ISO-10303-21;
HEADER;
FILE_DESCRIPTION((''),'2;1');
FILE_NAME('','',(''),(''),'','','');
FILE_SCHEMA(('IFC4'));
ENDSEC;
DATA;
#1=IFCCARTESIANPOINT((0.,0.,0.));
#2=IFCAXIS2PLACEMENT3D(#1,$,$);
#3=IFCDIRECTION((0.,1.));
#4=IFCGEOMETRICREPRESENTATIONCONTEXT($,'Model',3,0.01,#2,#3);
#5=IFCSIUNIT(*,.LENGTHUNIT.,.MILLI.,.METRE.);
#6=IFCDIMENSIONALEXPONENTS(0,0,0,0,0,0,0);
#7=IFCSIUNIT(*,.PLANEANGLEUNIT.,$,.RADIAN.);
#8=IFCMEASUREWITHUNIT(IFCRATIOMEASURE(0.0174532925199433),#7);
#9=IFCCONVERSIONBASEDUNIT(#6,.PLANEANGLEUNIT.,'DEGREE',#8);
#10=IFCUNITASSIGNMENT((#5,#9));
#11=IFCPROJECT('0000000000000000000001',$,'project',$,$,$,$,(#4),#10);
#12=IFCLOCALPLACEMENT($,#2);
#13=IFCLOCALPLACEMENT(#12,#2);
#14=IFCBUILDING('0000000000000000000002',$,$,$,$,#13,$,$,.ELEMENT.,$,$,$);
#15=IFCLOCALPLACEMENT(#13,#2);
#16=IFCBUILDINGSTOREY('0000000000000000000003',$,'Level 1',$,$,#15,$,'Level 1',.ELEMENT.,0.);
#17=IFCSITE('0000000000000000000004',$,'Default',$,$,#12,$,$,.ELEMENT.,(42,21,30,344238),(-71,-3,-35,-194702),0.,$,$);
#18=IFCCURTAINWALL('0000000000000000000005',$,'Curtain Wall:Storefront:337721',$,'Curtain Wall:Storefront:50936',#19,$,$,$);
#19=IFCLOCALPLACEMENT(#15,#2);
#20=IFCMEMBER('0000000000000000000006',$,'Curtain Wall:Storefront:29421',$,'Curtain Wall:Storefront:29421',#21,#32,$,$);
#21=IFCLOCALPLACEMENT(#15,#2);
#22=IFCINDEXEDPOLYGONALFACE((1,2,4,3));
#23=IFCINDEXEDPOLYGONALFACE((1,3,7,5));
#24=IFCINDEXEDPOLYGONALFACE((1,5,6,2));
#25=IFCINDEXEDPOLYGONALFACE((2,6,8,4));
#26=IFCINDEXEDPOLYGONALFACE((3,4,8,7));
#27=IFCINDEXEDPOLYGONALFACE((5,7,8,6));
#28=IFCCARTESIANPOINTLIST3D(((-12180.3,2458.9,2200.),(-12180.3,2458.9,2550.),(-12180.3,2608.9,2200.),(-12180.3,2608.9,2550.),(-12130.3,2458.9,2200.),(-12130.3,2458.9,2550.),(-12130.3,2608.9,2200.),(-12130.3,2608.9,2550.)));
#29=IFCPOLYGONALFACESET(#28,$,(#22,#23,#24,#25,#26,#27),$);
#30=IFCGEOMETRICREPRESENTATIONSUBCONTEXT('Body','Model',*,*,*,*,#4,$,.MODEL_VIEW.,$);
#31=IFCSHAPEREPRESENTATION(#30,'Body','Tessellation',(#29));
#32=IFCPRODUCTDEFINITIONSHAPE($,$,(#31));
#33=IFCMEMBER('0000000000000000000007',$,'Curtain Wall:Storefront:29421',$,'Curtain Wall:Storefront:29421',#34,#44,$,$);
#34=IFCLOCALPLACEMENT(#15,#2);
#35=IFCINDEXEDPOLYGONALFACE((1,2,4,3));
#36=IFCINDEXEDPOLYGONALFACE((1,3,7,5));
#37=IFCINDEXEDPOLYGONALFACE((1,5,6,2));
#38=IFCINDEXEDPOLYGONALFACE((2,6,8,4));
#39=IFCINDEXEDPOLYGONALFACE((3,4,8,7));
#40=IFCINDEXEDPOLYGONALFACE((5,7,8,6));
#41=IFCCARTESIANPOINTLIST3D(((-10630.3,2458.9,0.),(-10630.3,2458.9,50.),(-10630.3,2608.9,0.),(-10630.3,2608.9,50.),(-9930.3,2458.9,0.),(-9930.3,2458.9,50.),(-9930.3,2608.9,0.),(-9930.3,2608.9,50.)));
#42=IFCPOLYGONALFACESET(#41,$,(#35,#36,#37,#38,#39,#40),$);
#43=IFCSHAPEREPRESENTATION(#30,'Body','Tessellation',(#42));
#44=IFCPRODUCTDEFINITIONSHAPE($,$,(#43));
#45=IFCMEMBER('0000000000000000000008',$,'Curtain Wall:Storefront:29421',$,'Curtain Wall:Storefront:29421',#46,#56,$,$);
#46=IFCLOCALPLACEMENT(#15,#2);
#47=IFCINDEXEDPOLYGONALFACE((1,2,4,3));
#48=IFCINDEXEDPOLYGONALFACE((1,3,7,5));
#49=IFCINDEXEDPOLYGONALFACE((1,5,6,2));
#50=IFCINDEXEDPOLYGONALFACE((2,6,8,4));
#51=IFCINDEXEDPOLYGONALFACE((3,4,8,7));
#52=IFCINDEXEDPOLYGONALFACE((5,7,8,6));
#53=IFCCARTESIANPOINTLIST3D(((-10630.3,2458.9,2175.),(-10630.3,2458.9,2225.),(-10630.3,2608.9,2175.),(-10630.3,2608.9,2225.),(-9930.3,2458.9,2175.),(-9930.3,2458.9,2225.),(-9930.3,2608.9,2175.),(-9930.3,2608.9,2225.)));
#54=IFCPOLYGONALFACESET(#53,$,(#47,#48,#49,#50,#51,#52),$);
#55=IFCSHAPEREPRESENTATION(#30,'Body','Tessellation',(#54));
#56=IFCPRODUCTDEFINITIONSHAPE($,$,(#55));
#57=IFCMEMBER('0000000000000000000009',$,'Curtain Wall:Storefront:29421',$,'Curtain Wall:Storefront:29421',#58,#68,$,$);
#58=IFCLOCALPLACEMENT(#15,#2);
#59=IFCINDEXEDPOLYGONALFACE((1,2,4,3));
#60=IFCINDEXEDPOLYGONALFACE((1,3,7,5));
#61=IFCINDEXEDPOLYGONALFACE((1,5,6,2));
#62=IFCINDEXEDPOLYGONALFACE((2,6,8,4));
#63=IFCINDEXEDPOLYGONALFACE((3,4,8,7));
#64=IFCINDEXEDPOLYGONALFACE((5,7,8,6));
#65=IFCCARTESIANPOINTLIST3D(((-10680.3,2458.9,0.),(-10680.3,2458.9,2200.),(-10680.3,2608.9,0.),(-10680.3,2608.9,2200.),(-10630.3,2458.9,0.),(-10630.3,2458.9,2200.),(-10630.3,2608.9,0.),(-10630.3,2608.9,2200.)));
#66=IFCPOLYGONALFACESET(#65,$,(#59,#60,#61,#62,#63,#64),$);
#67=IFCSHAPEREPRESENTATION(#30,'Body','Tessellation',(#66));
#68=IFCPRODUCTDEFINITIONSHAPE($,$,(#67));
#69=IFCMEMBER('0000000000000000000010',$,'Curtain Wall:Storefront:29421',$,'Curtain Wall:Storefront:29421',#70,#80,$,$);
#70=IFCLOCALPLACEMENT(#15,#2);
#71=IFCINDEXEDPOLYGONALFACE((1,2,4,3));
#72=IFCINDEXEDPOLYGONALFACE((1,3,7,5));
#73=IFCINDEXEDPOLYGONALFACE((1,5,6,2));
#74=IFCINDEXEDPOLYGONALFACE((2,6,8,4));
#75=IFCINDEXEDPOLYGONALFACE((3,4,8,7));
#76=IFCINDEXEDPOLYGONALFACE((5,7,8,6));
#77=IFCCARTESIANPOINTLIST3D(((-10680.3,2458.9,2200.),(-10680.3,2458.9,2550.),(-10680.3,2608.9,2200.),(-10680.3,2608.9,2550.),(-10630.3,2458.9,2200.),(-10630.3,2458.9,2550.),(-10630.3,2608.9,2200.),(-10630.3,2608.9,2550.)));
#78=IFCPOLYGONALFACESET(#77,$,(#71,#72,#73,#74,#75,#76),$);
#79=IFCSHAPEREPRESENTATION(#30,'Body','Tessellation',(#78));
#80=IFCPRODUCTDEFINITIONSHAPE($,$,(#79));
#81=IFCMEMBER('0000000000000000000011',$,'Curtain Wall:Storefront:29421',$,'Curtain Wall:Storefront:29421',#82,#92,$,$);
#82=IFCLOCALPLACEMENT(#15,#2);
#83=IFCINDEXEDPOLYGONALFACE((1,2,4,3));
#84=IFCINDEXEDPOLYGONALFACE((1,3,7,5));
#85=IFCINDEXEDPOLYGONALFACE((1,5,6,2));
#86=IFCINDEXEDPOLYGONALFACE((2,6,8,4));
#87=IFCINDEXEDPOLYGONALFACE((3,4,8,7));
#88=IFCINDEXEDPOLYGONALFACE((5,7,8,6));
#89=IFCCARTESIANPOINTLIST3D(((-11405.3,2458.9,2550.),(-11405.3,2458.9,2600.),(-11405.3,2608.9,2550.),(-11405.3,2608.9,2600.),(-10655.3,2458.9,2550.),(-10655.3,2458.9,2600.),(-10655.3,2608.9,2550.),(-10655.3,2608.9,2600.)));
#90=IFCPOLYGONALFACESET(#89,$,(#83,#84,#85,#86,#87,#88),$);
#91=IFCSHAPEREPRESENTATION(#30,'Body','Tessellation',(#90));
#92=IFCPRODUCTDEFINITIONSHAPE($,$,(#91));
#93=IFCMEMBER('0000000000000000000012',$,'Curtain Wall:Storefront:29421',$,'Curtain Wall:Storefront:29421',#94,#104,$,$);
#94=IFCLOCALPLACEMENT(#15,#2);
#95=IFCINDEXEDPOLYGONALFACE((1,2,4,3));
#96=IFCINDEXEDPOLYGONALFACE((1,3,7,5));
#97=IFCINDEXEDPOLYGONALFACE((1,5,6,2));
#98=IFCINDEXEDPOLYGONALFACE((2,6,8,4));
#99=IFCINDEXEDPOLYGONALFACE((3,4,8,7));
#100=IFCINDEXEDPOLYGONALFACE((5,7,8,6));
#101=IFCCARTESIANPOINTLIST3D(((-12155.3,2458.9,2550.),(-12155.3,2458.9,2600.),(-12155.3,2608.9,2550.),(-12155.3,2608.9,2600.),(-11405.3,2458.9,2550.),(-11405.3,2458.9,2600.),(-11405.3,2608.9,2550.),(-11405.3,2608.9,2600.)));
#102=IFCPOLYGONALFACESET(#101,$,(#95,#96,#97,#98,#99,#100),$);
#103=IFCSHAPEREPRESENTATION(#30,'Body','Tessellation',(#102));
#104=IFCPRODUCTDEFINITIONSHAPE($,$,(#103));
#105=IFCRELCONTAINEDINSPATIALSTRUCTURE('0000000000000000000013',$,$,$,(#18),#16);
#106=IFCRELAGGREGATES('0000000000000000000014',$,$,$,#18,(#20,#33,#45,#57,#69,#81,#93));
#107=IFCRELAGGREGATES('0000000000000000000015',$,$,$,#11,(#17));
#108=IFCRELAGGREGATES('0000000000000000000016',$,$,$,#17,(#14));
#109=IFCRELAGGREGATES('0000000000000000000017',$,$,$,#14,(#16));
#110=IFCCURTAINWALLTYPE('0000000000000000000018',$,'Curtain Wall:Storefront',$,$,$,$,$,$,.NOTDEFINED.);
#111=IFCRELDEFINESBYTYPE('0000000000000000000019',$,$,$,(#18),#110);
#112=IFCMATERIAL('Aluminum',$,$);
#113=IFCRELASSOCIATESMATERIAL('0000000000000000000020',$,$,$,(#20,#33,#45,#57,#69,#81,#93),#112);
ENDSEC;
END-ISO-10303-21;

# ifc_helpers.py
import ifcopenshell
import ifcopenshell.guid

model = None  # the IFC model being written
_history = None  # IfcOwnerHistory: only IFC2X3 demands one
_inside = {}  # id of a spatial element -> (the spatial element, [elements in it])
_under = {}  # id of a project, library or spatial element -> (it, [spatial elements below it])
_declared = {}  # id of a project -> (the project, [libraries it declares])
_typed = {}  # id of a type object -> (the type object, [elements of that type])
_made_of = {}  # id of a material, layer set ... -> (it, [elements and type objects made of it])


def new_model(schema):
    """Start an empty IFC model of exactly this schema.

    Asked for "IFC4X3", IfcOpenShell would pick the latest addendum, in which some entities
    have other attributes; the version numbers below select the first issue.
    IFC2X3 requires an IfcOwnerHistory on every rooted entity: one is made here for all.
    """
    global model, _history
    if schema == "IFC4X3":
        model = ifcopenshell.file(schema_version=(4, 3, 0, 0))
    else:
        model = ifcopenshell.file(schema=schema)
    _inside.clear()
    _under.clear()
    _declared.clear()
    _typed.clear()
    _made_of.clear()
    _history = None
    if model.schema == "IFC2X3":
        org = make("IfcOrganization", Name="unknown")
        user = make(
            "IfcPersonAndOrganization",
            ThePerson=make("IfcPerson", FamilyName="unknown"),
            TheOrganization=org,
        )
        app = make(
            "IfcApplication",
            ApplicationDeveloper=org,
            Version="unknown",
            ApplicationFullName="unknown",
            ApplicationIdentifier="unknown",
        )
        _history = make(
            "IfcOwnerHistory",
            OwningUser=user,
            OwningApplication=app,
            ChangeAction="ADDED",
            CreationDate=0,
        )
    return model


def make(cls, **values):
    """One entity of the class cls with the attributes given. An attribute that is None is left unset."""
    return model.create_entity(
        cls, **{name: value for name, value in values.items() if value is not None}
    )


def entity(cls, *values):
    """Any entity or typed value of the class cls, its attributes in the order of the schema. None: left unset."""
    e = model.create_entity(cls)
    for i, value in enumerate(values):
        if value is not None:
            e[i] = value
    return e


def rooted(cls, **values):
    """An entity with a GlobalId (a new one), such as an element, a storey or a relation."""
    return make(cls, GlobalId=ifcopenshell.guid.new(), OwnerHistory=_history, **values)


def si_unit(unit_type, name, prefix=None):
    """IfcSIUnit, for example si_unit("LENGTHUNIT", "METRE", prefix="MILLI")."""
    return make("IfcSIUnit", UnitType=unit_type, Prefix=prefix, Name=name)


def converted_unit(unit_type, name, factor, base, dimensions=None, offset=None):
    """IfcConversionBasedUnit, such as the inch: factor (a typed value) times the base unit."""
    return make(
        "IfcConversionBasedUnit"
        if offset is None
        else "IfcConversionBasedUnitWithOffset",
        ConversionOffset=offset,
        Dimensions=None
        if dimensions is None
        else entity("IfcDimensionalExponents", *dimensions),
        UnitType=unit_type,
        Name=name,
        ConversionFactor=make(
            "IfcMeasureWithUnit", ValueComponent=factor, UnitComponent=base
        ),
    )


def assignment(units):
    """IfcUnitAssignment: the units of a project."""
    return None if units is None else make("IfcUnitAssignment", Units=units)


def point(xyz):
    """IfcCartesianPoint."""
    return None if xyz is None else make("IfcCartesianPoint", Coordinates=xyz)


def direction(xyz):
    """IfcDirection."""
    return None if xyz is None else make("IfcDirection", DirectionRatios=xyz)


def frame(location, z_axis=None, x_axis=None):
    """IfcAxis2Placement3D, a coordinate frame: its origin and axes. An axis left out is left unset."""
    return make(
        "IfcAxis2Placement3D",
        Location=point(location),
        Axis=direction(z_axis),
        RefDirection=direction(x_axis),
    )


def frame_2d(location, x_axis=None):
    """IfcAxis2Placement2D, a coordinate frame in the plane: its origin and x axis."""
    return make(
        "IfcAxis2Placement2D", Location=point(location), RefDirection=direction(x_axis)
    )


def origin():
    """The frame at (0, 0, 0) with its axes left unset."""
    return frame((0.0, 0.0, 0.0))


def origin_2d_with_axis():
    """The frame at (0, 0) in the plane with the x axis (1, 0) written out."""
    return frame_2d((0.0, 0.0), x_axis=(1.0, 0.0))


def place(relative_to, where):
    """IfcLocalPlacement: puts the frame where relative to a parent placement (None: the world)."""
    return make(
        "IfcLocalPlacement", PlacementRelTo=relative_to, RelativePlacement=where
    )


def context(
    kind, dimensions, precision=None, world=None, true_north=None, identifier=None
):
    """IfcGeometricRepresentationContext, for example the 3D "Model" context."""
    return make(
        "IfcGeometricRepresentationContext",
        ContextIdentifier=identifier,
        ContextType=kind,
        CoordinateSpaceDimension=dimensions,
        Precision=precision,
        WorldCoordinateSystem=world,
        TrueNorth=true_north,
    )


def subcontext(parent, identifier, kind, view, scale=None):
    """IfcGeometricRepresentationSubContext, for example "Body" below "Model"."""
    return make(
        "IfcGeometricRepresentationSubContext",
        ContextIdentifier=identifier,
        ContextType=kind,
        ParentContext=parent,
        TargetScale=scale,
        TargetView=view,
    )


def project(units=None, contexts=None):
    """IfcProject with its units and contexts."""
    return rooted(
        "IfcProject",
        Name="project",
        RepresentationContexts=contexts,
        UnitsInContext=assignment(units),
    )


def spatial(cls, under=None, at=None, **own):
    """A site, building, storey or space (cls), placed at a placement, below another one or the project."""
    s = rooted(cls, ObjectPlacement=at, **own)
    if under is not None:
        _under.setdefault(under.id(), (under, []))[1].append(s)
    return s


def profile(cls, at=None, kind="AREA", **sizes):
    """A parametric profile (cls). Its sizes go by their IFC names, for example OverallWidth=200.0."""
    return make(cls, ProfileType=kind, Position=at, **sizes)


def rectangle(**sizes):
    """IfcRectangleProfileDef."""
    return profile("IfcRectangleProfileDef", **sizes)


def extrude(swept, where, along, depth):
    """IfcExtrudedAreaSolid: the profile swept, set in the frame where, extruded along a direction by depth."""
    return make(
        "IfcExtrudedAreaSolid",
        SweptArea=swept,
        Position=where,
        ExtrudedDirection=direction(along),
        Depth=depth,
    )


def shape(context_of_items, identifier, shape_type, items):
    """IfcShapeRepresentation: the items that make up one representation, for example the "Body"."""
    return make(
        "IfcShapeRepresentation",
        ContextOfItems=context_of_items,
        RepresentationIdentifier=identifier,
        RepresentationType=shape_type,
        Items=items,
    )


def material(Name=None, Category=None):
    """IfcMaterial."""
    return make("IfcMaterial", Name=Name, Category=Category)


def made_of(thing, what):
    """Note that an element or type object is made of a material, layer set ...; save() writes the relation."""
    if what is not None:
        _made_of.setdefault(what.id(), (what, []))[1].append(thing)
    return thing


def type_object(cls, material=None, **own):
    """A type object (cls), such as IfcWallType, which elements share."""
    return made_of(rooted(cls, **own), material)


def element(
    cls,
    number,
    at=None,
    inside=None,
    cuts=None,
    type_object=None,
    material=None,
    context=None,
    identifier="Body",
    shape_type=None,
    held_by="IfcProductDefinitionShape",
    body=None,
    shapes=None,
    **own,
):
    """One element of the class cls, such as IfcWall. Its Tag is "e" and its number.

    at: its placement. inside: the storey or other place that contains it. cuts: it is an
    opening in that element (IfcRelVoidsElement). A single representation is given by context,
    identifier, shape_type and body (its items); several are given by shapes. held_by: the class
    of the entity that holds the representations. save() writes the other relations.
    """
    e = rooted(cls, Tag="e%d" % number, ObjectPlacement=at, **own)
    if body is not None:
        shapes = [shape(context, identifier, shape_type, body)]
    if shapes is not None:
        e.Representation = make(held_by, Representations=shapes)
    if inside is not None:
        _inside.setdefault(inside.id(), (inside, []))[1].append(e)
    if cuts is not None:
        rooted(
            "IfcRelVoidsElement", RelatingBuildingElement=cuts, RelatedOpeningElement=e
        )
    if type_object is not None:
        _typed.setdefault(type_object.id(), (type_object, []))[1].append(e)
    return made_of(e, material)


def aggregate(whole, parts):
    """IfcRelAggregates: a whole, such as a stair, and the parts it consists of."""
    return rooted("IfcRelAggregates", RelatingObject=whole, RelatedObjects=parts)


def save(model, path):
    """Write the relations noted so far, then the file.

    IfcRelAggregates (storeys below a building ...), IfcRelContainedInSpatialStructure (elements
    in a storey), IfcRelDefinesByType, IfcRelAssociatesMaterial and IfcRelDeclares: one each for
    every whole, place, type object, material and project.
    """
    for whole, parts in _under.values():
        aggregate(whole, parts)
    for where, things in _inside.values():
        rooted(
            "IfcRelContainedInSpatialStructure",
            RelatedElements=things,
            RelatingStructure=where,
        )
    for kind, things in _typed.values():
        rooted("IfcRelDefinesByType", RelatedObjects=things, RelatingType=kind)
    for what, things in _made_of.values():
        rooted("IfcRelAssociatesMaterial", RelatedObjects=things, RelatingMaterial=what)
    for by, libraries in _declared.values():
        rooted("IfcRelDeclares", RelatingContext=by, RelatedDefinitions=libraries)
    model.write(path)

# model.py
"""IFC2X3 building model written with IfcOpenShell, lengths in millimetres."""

from ifc_helpers import new_model, entity, si_unit, converted_unit, direction, frame, frame_2d, origin, origin_2d_with_axis, place, context, subcontext, project, spatial, rectangle, extrude, material, type_object, element, aggregate, save


model = new_model("IFC2X3")

# Units and contexts
model_context = context("Model", 3, precision=0.01, world=origin(), true_north=direction((0.0, 1.0)))
body_context = subcontext(model_context, "Body", "Model", "MODEL_VIEW")
ifc_project = project(units=[si_unit("LENGTHUNIT", "METRE", prefix="MILLI"), converted_unit("PLANEANGLEUNIT", "DEGREE", entity("IfcRatioMeasure", 0.0174532925199433), si_unit("PLANEANGLEUNIT", "RADIAN"), dimensions=[0, 0, 0, 0, 0, 0, 0])], contexts=[model_context])

# Site, building, storey
site_placement = place(None, origin())
site = spatial("IfcSite", under=ifc_project, at=site_placement, Name="Default", CompositionType="ELEMENT", RefLatitude=(42, 21, 30, 344238), RefLongitude=(-71, -3, -35, -194702), RefElevation=0.0)
building_placement = place(site_placement, origin())
building = spatial("IfcBuilding", under=site, at=building_placement, CompositionType="ELEMENT")
storey_placement = place(building_placement, origin())
storey = spatial("IfcBuildingStorey", under=building, at=storey_placement, Name="Level 1", LongName="Level 1", CompositionType="ELEMENT", Elevation=0.0)

# Curtain wall, members
curtain_wall_type = type_object("IfcCurtainWallType", Name="Curtain Wall:Storefront", PredefinedType="NOTDEFINED")
curtain_wall_placement = place(storey_placement, origin())
curtain_wall = element("IfcCurtainWall", 1, at=curtain_wall_placement, inside=storey, type_object=curtain_wall_type, Name="Curtain Wall:Storefront:337721", ObjectType="Curtain Wall:Storefront:50936")
ifc_material = material(Name="Aluminum")
member_1_placement = place(curtain_wall_placement, origin())
member_1 = element("IfcMember", 2, at=member_1_placement, material=ifc_material, Name="Curtain Wall:Storefront:29421", ObjectType="Curtain Wall:Storefront:29421", context=body_context, shape_type="SweptSolid", body=[
    extrude(rectangle(XDim=50.0, YDim=150.0, at=frame_2d((0.0, 0.0), x_axis=(1.0, 0.0))), frame((-12155.3, 2533.9, 2200.0), z_axis=(0.0, 0.0, 1.0), x_axis=(-1.0, 0.0, 0.0)), (0.0, 0.0, 1.0), 350.0),
])
member_2_placement = place(curtain_wall_placement, origin())
member_2 = element("IfcMember", 3, at=member_2_placement, material=ifc_material, Name="Curtain Wall:Storefront:29421", ObjectType="Curtain Wall:Storefront:29421", context=body_context, shape_type="SweptSolid", body=[
    extrude(rectangle(XDim=50.0, YDim=150.0, at=frame_2d((0.0, 0.0), x_axis=(1.0, 0.0))), frame((-10630.3, 2533.9, 25.0), z_axis=(1.0, 0.0, 0.0), x_axis=(0.0, 0.0, -1.0)), (0.0, 0.0, 1.0), 700.0),
])
member_3_placement = place(curtain_wall_placement, origin())
member_3 = element("IfcMember", 4, at=member_3_placement, material=ifc_material, Name="Curtain Wall:Storefront:29421", ObjectType="Curtain Wall:Storefront:29421", context=body_context, shape_type="SweptSolid", body=[
    extrude(rectangle(XDim=50.0, YDim=150.0, at=frame_2d((0.0, 0.0), x_axis=(1.0, 0.0))), frame((-9930.3, 2533.9, 2200.0), z_axis=(-1.0, 0.0, 0.0), x_axis=(0.0, 0.0, -1.0)), (0.0, 0.0, 1.0), 700.0),
])
member_4_placement = place(curtain_wall_placement, origin())
member_4 = element("IfcMember", 5, at=member_4_placement, material=ifc_material, Name="Curtain Wall:Storefront:29421", ObjectType="Curtain Wall:Storefront:29421", context=body_context, shape_type="SweptSolid", body=[
    extrude(rectangle(XDim=50.0, YDim=150.0, at=origin_2d_with_axis()), frame((-10655.3, 2533.9, 0.0), z_axis=(0.0, 0.0, 1.0), x_axis=(-1.0, 0.0, 0.0)), (0.0, 0.0, 1.0), 2200.0),
])
member_5_placement = place(curtain_wall_placement, origin())
member_5 = element("IfcMember", 6, at=member_5_placement, material=ifc_material, Name="Curtain Wall:Storefront:29421", ObjectType="Curtain Wall:Storefront:29421", context=body_context, shape_type="SweptSolid", body=[
    extrude(rectangle(XDim=50.0, YDim=150.0, at=origin_2d_with_axis()), frame((-10655.3, 2533.9, 2200.0), z_axis=(0.0, 0.0, 1.0), x_axis=(-1.0, 0.0, 0.0)), (0.0, 0.0, 1.0), 350.0),
])
member_6_placement = place(curtain_wall_placement, origin())
member_6 = element("IfcMember", 7, at=member_6_placement, material=ifc_material, Name="Curtain Wall:Storefront:29421", ObjectType="Curtain Wall:Storefront:29421", context=body_context, shape_type="SweptSolid", body=[
    extrude(rectangle(XDim=50.0, YDim=150.0, at=frame_2d((0.0, 0.0), x_axis=(1.0, 0.0))), frame((-10655.3, 2533.9, 2575.0), z_axis=(-1.0, 0.0, 0.0), x_axis=(0.0, 0.0, -1.0)), (0.0, 0.0, 1.0), 750.0),
])
member_7_placement = place(curtain_wall_placement, origin())
member_7 = element("IfcMember", 8, at=member_7_placement, material=ifc_material, Name="Curtain Wall:Storefront:29421", ObjectType="Curtain Wall:Storefront:29421", context=body_context, shape_type="SweptSolid", body=[
    extrude(rectangle(XDim=50.0, YDim=150.0, at=frame_2d((0.0, 0.0), x_axis=(1.0, 0.0))), frame((-11405.3, 2533.9, 2575.0), z_axis=(-1.0, 0.0, 0.0), x_axis=(0.0, 0.0, -1.0)), (0.0, 0.0, 1.0), 750.0),
])
aggregate(curtain_wall, [member_1, member_2, member_3, member_4, member_5, member_6, member_7])

save(model, "model.ifc")
